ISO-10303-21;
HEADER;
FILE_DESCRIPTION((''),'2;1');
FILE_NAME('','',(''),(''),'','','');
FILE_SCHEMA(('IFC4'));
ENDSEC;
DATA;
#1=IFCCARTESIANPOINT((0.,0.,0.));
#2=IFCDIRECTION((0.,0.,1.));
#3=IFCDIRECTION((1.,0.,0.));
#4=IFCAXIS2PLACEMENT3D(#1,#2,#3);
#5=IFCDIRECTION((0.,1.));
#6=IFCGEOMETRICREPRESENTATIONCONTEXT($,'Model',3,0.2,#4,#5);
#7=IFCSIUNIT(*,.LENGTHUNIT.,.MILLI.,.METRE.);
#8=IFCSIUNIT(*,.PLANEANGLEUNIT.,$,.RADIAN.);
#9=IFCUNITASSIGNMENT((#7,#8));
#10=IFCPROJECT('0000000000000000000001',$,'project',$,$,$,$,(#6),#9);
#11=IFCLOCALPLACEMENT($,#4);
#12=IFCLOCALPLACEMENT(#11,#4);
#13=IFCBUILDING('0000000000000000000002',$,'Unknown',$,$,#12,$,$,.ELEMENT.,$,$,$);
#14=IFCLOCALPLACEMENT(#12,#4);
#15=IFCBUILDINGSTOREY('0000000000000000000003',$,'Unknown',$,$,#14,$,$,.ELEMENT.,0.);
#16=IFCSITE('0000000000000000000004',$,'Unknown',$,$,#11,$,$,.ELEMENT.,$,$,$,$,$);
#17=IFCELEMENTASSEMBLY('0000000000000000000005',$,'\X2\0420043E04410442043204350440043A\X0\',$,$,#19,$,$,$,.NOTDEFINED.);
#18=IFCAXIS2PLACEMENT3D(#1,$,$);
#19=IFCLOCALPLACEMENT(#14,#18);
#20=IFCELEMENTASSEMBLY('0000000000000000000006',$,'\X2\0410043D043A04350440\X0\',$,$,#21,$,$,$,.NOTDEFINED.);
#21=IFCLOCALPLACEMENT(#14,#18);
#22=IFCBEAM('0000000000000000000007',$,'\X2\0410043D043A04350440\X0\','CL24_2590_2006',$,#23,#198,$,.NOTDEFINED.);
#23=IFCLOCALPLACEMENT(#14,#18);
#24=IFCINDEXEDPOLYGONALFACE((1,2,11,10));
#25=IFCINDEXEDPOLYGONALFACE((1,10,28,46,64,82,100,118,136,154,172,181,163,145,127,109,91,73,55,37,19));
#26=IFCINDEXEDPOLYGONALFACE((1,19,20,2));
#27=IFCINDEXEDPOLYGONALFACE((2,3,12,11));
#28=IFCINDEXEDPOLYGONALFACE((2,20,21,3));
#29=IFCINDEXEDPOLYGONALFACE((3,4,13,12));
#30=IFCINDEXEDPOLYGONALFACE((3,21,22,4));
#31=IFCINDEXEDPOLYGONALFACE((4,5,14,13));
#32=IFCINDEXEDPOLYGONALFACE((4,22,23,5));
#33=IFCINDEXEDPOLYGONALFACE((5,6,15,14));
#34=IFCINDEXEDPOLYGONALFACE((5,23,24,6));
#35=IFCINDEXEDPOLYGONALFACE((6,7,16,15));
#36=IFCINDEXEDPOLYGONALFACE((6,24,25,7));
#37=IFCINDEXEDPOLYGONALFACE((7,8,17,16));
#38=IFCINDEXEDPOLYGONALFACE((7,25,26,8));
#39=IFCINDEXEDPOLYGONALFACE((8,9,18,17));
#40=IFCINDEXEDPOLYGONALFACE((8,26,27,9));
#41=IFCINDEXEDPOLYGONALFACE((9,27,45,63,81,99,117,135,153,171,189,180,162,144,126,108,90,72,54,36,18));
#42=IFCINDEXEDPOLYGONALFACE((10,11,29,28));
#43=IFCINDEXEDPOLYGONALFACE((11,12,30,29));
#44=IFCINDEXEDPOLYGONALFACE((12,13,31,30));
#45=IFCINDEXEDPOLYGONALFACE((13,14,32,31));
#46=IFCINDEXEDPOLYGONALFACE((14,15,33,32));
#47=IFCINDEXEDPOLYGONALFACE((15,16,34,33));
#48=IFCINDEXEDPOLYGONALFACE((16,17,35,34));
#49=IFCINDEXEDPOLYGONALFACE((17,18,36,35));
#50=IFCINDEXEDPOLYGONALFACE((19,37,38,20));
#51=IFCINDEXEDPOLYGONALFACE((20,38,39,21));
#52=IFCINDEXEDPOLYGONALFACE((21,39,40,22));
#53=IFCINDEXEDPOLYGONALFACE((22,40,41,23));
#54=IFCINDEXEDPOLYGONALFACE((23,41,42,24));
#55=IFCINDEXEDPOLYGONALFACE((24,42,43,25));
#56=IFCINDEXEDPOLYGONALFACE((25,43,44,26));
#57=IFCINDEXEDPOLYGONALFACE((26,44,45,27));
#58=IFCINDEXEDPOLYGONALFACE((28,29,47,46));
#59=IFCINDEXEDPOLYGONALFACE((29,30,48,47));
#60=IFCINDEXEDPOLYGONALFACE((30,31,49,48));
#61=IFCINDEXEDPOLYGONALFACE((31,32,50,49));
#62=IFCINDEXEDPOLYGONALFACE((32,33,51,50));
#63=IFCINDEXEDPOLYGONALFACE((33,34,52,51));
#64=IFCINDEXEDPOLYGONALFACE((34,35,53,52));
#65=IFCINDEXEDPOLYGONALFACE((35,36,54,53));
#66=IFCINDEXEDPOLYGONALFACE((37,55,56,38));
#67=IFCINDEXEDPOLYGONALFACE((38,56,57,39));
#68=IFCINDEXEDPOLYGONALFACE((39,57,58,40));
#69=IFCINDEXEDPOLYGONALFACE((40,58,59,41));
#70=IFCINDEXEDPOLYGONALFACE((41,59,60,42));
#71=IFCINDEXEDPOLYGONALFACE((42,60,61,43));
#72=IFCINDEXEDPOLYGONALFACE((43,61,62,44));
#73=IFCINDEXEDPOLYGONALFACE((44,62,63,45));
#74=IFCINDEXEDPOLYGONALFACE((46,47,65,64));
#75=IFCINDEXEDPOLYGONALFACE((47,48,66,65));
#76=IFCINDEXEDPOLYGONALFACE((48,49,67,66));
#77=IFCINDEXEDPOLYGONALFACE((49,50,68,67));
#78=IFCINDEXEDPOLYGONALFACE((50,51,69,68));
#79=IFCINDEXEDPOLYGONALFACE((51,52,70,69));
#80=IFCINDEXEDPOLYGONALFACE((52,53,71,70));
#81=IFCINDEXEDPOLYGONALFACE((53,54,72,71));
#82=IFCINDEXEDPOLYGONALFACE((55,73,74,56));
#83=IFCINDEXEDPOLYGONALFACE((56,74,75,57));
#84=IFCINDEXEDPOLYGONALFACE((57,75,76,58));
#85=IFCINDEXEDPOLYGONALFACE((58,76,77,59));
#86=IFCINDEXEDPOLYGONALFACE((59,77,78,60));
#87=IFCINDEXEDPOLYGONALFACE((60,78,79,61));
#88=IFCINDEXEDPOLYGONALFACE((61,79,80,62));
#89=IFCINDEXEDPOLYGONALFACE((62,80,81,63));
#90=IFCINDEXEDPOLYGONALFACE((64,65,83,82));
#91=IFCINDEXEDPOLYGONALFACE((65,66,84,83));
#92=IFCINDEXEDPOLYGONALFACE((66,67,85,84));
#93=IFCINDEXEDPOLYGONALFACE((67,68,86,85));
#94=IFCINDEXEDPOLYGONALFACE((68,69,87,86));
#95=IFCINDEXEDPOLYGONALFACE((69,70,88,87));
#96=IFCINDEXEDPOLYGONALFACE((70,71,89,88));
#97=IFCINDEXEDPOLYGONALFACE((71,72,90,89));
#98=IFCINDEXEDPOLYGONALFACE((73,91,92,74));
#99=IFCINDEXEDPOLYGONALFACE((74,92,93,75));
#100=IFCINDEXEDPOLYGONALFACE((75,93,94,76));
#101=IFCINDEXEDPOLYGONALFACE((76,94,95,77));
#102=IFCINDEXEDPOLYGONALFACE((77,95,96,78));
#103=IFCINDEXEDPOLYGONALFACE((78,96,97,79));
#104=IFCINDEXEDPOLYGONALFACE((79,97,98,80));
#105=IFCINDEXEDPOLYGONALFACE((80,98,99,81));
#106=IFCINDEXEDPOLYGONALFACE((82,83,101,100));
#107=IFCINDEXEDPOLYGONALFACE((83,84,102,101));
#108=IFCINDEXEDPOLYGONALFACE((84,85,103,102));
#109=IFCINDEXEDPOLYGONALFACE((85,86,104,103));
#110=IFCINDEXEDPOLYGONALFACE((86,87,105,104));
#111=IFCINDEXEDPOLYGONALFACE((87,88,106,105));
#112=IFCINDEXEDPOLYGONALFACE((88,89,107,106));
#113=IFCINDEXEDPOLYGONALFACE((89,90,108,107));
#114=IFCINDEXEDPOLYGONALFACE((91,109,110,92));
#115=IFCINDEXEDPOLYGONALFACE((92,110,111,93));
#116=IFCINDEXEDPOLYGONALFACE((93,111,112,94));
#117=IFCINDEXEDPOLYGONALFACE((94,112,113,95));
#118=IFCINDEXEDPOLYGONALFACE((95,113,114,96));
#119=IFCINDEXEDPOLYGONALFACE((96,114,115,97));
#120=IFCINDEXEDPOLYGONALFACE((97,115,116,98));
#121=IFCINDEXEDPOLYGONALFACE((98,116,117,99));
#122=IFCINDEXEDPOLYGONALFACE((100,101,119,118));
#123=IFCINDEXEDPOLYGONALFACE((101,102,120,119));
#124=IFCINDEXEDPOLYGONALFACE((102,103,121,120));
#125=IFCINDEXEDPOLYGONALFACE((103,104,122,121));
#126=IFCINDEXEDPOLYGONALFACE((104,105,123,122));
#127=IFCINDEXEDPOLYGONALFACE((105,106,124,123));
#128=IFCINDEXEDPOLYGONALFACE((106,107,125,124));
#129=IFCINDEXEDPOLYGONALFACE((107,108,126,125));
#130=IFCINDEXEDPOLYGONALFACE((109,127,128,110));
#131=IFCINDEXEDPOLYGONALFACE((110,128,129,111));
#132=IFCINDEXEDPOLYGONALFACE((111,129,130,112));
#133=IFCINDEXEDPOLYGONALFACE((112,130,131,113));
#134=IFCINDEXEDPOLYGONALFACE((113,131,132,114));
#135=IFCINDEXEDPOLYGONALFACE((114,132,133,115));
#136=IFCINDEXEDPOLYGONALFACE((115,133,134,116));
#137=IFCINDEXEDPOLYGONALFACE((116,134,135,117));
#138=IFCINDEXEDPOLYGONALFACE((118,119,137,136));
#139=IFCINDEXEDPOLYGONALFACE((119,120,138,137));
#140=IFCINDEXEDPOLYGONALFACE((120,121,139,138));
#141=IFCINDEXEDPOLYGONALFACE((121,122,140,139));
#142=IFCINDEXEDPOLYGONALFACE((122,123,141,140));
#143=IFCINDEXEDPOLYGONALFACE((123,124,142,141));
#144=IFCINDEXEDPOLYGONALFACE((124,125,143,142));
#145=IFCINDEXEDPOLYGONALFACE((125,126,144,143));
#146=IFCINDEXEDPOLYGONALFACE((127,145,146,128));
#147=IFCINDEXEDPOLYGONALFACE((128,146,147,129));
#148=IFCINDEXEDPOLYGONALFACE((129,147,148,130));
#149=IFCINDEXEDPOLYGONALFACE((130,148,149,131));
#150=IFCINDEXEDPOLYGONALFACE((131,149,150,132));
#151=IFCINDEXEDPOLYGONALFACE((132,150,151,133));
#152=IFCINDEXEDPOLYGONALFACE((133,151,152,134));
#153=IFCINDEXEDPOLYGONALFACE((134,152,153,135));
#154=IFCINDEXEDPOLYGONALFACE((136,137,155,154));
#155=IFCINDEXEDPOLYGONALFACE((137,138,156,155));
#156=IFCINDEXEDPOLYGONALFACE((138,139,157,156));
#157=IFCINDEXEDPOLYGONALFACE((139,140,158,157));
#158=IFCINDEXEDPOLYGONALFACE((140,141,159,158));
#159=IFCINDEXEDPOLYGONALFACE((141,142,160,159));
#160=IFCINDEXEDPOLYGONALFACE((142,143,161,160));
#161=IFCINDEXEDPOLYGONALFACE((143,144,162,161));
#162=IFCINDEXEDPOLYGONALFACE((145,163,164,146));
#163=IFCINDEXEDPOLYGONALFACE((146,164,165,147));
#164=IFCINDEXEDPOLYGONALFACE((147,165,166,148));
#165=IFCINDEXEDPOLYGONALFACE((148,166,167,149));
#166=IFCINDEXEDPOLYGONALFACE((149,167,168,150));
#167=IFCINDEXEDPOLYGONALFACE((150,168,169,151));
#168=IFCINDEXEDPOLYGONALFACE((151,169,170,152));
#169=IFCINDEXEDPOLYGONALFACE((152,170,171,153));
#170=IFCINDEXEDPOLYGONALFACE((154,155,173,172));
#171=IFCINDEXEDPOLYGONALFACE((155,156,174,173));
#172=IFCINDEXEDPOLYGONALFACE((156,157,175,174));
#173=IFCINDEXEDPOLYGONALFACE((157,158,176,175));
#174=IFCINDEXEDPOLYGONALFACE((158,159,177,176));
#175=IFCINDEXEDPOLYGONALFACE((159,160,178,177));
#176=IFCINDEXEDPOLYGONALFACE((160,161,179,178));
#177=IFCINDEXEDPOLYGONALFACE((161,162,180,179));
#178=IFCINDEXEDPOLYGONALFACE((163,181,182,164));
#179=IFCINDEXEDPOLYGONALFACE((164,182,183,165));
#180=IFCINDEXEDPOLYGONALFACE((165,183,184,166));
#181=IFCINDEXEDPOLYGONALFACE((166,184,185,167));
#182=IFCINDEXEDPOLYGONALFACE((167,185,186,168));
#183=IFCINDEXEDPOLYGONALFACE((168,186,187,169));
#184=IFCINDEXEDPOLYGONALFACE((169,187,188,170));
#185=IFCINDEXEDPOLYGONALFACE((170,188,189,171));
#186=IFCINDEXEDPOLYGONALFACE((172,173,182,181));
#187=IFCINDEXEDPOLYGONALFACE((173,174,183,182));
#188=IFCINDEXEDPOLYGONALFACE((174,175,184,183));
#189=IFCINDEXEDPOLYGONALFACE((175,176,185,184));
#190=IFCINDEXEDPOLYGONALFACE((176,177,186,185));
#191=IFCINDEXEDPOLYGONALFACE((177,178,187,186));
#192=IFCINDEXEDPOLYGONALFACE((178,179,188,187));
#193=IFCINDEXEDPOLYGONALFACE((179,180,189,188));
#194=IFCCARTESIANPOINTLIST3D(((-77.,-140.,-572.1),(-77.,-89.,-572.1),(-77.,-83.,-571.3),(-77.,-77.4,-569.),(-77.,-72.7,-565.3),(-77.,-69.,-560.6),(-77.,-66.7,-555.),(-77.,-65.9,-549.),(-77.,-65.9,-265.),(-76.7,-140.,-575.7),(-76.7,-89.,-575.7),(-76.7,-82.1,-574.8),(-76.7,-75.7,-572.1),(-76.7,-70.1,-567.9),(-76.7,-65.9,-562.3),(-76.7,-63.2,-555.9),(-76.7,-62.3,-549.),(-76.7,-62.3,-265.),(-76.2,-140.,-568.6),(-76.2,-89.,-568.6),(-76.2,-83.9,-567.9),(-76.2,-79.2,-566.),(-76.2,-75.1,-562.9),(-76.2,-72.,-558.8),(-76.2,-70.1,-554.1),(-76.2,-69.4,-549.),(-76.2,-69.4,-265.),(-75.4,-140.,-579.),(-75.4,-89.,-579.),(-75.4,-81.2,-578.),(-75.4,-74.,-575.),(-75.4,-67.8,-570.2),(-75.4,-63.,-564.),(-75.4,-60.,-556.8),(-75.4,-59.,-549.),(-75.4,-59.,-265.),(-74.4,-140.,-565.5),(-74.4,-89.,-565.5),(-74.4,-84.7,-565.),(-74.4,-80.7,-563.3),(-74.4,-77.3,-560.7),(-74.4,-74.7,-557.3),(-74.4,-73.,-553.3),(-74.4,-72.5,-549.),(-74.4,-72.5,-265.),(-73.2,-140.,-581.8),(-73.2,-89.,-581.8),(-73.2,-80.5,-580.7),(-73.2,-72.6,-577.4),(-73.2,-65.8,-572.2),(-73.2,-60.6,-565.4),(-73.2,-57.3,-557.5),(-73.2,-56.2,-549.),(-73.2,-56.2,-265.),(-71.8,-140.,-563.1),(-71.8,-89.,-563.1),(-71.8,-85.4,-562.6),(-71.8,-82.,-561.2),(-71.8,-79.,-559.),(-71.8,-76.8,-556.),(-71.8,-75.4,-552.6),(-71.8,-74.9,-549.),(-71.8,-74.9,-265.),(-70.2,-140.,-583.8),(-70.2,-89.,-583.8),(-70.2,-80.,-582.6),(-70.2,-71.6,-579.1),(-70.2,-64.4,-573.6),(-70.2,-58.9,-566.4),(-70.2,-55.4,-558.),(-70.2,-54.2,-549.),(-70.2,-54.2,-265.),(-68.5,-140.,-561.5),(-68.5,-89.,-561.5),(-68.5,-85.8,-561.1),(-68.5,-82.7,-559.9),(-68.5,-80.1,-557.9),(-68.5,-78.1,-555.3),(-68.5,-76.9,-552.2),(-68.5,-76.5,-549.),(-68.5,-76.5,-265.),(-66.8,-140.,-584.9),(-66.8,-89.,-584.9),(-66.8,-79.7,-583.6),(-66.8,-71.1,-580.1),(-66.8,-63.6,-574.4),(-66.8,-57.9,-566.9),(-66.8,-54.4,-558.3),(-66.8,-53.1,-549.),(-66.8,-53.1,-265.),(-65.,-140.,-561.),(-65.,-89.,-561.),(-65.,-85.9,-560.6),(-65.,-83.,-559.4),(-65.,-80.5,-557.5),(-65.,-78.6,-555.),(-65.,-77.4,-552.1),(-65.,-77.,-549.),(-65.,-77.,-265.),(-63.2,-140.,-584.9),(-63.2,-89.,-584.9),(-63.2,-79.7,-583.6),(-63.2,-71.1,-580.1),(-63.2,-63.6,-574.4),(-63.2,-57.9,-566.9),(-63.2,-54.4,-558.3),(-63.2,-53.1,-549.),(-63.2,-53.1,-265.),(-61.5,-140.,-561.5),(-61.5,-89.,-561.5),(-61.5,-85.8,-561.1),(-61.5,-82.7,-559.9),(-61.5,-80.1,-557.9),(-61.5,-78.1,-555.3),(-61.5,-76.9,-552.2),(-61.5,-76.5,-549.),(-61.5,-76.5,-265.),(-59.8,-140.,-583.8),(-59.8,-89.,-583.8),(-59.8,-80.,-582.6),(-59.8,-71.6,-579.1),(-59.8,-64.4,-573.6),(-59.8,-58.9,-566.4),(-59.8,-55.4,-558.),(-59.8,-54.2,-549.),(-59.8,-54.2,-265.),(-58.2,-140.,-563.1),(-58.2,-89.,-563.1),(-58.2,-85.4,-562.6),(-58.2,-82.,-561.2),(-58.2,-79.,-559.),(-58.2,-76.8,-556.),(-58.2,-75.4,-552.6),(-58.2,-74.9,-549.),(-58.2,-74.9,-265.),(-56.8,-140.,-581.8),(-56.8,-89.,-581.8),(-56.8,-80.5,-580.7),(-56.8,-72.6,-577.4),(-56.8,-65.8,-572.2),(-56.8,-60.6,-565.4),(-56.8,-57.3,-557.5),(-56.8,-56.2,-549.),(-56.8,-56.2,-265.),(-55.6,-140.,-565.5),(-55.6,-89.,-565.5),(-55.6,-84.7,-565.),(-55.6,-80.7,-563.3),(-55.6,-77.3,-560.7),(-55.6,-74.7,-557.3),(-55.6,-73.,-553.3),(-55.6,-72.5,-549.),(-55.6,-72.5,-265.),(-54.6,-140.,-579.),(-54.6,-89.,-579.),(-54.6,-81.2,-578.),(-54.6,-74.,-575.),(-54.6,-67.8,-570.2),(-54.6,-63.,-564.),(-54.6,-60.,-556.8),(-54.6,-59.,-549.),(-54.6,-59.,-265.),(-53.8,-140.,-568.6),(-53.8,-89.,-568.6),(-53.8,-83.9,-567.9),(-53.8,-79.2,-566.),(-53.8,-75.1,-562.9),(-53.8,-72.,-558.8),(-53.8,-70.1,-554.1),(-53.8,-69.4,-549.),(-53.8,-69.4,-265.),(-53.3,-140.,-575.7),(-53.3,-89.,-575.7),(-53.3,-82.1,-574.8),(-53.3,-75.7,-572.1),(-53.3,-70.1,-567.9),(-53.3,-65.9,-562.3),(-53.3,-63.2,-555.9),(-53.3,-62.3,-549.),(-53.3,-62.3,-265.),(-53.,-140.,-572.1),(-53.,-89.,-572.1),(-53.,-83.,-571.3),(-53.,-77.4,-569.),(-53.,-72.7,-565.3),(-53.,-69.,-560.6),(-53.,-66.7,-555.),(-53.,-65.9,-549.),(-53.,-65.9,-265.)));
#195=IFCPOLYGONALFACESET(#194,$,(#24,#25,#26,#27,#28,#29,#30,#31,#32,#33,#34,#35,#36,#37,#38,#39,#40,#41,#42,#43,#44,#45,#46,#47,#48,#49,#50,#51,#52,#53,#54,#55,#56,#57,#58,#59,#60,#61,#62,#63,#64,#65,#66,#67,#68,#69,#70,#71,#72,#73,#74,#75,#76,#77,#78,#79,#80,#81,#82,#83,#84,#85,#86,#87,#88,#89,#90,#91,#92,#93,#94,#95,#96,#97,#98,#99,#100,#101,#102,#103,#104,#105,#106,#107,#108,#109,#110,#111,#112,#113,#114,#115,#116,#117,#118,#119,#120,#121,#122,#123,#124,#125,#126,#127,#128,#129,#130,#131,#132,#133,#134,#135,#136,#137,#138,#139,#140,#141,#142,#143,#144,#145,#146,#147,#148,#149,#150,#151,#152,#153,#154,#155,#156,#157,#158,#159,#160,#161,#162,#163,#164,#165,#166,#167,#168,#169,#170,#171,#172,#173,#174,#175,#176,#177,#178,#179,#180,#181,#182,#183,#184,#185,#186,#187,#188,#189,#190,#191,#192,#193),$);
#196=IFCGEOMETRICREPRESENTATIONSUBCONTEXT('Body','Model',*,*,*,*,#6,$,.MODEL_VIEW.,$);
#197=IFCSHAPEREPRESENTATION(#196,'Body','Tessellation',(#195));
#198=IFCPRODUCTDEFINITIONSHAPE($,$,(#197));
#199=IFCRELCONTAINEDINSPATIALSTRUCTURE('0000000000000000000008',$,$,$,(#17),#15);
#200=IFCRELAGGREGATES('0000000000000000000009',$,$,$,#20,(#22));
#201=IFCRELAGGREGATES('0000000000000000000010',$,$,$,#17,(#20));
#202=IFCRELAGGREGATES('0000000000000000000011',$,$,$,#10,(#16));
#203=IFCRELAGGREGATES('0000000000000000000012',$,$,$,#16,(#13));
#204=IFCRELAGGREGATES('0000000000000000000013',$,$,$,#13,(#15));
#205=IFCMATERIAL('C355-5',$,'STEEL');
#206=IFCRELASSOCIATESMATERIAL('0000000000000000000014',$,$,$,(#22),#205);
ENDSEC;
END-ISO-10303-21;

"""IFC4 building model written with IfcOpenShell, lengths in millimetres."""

from ifc_helpers import new_model, entity, si_unit, direction, frame, origin_with_axes, place, context, subcontext, project, spatial, line, indexed_curve, outline, extrude, material, element, aggregate, save


model = new_model("IFC4")

# Units and contexts
model_context = context("Model", 3, precision=0.2, world=origin_with_axes(), true_north=direction((0.0, 1.0)))
body_context = subcontext(model_context, "Body", "Model", "MODEL_VIEW")
ifc_project = project(units=[si_unit("LENGTHUNIT", "METRE", prefix="MILLI"), si_unit("PLANEANGLEUNIT", "RADIAN")], contexts=[model_context])

# Site, building, storey
site_placement = place(None, origin_with_axes())
site = spatial("IfcSite", under=ifc_project, at=site_placement, Name="Unknown", CompositionType="ELEMENT")
building_placement = place(site_placement, origin_with_axes())
building = spatial("IfcBuilding", under=site, at=building_placement, Name="Unknown", CompositionType="ELEMENT")
storey_placement = place(building_placement, origin_with_axes())
storey = spatial("IfcBuildingStorey", under=building, at=storey_placement, Name="Unknown", CompositionType="ELEMENT", Elevation=0.0)

# Element assemblies, beam, voiding feature
assembly_1_placement = place(storey_placement, frame((80.0, 80.0, -300.0), z_axis=(0.0, -1.0, 0.0), x_axis=(0.0, 0.0, -1.0)))
assembly_1 = element("IfcElementAssembly", 1, at=assembly_1_placement, inside=storey, Name="Ростверк", PredefinedType="NOTDEFINED")
ifc_material_1 = material(Name="C355-5", Category="STEEL")
assembly_2_placement = place(assembly_1_placement, frame((-215.0, -145.0, 145.0), z_axis=(0.0, 0.0, 1.0), x_axis=(1.0, 0.0, 0.0)))
assembly_2 = element("IfcElementAssembly", 2, at=assembly_2_placement, Name="Анкер", PredefinedType="NOTDEFINED")
beam_1_placement = place(assembly_2_placement, origin_with_axes())
beam_1 = element("IfcBeam", 3, at=beam_1_placement, material=ifc_material_1, Name="Анкер", Description="CL24_2590_2006", PredefinedType="NOTDEFINED", context=body_context, shape_type="SolidModel", body=[
    entity("IfcSweptDiskSolid", entity("IfcIndexedPolyCurve", entity("IfcCartesianPointList3D", [[0.0, 0.0, 0.0], [464.0, 0.0, 0.0], [481.0, 0.0, 7.0], [488.0, 0.0, 24.0], [488.0, 0.0, 75.0]]), [entity("IfcLineIndex", [1, 2]), entity("IfcArcIndex", [2, 3, 4]), entity("IfcLineIndex", [4, 5])]), 12.0),
])
voiding_feature_1_placement = place(beam_1_placement, frame((0.0, 0.0, 0.0), z_axis=(0.0, -1.0, 0.0), x_axis=(1.0, 0.0, 0.0)))
element("IfcVoidingFeature", 4, at=voiding_feature_1_placement, cuts=beam_1, Name="Анкер", PredefinedType="HOLE", context=body_context, shape_type="SolidModel", body=[
    extrude(outline(indexed_curve([(12.5, 0.0), (12.2, 2.8), (11.3, 5.4), (9.8, 7.8), (7.8, 9.8), (5.4, 11.3), (2.8, 12.2), (0.0, 12.5), (-2.8, 12.2), (-5.4, 11.3), (-7.8, 9.8), (-9.8, 7.8), (-11.3, 5.4), (-12.2, 2.8), (-12.5, 0.0), (-12.2, -2.8), (-11.3, -5.4), (-9.8, -7.8), (-7.8, -9.8), (-5.4, -11.3), (-2.8, -12.2), (0.0, -12.5), (2.8, -12.2), (5.4, -11.3), (7.8, -9.8), (9.8, -7.8), (11.3, -5.4), (12.2, -2.8)], segments=[line(1, 2, 3, 4, 5, 6, 7, 8, 9, 10, 11, 12, 13, 14, 15, 16, 17, 18, 19, 20, 21, 22, 23, 24, 25, 26, 27, 28, 1)])), frame((0.0, 0.0, 0.0), z_axis=(-1.0, 0.0, 0.0), x_axis=(0.0, 0.0, 1.0)), (0.0, 0.0, -1.0), 180.0),
])
aggregate(assembly_2, [beam_1])
aggregate(assembly_1, [assembly_2])

save(model, "model.ifc")
